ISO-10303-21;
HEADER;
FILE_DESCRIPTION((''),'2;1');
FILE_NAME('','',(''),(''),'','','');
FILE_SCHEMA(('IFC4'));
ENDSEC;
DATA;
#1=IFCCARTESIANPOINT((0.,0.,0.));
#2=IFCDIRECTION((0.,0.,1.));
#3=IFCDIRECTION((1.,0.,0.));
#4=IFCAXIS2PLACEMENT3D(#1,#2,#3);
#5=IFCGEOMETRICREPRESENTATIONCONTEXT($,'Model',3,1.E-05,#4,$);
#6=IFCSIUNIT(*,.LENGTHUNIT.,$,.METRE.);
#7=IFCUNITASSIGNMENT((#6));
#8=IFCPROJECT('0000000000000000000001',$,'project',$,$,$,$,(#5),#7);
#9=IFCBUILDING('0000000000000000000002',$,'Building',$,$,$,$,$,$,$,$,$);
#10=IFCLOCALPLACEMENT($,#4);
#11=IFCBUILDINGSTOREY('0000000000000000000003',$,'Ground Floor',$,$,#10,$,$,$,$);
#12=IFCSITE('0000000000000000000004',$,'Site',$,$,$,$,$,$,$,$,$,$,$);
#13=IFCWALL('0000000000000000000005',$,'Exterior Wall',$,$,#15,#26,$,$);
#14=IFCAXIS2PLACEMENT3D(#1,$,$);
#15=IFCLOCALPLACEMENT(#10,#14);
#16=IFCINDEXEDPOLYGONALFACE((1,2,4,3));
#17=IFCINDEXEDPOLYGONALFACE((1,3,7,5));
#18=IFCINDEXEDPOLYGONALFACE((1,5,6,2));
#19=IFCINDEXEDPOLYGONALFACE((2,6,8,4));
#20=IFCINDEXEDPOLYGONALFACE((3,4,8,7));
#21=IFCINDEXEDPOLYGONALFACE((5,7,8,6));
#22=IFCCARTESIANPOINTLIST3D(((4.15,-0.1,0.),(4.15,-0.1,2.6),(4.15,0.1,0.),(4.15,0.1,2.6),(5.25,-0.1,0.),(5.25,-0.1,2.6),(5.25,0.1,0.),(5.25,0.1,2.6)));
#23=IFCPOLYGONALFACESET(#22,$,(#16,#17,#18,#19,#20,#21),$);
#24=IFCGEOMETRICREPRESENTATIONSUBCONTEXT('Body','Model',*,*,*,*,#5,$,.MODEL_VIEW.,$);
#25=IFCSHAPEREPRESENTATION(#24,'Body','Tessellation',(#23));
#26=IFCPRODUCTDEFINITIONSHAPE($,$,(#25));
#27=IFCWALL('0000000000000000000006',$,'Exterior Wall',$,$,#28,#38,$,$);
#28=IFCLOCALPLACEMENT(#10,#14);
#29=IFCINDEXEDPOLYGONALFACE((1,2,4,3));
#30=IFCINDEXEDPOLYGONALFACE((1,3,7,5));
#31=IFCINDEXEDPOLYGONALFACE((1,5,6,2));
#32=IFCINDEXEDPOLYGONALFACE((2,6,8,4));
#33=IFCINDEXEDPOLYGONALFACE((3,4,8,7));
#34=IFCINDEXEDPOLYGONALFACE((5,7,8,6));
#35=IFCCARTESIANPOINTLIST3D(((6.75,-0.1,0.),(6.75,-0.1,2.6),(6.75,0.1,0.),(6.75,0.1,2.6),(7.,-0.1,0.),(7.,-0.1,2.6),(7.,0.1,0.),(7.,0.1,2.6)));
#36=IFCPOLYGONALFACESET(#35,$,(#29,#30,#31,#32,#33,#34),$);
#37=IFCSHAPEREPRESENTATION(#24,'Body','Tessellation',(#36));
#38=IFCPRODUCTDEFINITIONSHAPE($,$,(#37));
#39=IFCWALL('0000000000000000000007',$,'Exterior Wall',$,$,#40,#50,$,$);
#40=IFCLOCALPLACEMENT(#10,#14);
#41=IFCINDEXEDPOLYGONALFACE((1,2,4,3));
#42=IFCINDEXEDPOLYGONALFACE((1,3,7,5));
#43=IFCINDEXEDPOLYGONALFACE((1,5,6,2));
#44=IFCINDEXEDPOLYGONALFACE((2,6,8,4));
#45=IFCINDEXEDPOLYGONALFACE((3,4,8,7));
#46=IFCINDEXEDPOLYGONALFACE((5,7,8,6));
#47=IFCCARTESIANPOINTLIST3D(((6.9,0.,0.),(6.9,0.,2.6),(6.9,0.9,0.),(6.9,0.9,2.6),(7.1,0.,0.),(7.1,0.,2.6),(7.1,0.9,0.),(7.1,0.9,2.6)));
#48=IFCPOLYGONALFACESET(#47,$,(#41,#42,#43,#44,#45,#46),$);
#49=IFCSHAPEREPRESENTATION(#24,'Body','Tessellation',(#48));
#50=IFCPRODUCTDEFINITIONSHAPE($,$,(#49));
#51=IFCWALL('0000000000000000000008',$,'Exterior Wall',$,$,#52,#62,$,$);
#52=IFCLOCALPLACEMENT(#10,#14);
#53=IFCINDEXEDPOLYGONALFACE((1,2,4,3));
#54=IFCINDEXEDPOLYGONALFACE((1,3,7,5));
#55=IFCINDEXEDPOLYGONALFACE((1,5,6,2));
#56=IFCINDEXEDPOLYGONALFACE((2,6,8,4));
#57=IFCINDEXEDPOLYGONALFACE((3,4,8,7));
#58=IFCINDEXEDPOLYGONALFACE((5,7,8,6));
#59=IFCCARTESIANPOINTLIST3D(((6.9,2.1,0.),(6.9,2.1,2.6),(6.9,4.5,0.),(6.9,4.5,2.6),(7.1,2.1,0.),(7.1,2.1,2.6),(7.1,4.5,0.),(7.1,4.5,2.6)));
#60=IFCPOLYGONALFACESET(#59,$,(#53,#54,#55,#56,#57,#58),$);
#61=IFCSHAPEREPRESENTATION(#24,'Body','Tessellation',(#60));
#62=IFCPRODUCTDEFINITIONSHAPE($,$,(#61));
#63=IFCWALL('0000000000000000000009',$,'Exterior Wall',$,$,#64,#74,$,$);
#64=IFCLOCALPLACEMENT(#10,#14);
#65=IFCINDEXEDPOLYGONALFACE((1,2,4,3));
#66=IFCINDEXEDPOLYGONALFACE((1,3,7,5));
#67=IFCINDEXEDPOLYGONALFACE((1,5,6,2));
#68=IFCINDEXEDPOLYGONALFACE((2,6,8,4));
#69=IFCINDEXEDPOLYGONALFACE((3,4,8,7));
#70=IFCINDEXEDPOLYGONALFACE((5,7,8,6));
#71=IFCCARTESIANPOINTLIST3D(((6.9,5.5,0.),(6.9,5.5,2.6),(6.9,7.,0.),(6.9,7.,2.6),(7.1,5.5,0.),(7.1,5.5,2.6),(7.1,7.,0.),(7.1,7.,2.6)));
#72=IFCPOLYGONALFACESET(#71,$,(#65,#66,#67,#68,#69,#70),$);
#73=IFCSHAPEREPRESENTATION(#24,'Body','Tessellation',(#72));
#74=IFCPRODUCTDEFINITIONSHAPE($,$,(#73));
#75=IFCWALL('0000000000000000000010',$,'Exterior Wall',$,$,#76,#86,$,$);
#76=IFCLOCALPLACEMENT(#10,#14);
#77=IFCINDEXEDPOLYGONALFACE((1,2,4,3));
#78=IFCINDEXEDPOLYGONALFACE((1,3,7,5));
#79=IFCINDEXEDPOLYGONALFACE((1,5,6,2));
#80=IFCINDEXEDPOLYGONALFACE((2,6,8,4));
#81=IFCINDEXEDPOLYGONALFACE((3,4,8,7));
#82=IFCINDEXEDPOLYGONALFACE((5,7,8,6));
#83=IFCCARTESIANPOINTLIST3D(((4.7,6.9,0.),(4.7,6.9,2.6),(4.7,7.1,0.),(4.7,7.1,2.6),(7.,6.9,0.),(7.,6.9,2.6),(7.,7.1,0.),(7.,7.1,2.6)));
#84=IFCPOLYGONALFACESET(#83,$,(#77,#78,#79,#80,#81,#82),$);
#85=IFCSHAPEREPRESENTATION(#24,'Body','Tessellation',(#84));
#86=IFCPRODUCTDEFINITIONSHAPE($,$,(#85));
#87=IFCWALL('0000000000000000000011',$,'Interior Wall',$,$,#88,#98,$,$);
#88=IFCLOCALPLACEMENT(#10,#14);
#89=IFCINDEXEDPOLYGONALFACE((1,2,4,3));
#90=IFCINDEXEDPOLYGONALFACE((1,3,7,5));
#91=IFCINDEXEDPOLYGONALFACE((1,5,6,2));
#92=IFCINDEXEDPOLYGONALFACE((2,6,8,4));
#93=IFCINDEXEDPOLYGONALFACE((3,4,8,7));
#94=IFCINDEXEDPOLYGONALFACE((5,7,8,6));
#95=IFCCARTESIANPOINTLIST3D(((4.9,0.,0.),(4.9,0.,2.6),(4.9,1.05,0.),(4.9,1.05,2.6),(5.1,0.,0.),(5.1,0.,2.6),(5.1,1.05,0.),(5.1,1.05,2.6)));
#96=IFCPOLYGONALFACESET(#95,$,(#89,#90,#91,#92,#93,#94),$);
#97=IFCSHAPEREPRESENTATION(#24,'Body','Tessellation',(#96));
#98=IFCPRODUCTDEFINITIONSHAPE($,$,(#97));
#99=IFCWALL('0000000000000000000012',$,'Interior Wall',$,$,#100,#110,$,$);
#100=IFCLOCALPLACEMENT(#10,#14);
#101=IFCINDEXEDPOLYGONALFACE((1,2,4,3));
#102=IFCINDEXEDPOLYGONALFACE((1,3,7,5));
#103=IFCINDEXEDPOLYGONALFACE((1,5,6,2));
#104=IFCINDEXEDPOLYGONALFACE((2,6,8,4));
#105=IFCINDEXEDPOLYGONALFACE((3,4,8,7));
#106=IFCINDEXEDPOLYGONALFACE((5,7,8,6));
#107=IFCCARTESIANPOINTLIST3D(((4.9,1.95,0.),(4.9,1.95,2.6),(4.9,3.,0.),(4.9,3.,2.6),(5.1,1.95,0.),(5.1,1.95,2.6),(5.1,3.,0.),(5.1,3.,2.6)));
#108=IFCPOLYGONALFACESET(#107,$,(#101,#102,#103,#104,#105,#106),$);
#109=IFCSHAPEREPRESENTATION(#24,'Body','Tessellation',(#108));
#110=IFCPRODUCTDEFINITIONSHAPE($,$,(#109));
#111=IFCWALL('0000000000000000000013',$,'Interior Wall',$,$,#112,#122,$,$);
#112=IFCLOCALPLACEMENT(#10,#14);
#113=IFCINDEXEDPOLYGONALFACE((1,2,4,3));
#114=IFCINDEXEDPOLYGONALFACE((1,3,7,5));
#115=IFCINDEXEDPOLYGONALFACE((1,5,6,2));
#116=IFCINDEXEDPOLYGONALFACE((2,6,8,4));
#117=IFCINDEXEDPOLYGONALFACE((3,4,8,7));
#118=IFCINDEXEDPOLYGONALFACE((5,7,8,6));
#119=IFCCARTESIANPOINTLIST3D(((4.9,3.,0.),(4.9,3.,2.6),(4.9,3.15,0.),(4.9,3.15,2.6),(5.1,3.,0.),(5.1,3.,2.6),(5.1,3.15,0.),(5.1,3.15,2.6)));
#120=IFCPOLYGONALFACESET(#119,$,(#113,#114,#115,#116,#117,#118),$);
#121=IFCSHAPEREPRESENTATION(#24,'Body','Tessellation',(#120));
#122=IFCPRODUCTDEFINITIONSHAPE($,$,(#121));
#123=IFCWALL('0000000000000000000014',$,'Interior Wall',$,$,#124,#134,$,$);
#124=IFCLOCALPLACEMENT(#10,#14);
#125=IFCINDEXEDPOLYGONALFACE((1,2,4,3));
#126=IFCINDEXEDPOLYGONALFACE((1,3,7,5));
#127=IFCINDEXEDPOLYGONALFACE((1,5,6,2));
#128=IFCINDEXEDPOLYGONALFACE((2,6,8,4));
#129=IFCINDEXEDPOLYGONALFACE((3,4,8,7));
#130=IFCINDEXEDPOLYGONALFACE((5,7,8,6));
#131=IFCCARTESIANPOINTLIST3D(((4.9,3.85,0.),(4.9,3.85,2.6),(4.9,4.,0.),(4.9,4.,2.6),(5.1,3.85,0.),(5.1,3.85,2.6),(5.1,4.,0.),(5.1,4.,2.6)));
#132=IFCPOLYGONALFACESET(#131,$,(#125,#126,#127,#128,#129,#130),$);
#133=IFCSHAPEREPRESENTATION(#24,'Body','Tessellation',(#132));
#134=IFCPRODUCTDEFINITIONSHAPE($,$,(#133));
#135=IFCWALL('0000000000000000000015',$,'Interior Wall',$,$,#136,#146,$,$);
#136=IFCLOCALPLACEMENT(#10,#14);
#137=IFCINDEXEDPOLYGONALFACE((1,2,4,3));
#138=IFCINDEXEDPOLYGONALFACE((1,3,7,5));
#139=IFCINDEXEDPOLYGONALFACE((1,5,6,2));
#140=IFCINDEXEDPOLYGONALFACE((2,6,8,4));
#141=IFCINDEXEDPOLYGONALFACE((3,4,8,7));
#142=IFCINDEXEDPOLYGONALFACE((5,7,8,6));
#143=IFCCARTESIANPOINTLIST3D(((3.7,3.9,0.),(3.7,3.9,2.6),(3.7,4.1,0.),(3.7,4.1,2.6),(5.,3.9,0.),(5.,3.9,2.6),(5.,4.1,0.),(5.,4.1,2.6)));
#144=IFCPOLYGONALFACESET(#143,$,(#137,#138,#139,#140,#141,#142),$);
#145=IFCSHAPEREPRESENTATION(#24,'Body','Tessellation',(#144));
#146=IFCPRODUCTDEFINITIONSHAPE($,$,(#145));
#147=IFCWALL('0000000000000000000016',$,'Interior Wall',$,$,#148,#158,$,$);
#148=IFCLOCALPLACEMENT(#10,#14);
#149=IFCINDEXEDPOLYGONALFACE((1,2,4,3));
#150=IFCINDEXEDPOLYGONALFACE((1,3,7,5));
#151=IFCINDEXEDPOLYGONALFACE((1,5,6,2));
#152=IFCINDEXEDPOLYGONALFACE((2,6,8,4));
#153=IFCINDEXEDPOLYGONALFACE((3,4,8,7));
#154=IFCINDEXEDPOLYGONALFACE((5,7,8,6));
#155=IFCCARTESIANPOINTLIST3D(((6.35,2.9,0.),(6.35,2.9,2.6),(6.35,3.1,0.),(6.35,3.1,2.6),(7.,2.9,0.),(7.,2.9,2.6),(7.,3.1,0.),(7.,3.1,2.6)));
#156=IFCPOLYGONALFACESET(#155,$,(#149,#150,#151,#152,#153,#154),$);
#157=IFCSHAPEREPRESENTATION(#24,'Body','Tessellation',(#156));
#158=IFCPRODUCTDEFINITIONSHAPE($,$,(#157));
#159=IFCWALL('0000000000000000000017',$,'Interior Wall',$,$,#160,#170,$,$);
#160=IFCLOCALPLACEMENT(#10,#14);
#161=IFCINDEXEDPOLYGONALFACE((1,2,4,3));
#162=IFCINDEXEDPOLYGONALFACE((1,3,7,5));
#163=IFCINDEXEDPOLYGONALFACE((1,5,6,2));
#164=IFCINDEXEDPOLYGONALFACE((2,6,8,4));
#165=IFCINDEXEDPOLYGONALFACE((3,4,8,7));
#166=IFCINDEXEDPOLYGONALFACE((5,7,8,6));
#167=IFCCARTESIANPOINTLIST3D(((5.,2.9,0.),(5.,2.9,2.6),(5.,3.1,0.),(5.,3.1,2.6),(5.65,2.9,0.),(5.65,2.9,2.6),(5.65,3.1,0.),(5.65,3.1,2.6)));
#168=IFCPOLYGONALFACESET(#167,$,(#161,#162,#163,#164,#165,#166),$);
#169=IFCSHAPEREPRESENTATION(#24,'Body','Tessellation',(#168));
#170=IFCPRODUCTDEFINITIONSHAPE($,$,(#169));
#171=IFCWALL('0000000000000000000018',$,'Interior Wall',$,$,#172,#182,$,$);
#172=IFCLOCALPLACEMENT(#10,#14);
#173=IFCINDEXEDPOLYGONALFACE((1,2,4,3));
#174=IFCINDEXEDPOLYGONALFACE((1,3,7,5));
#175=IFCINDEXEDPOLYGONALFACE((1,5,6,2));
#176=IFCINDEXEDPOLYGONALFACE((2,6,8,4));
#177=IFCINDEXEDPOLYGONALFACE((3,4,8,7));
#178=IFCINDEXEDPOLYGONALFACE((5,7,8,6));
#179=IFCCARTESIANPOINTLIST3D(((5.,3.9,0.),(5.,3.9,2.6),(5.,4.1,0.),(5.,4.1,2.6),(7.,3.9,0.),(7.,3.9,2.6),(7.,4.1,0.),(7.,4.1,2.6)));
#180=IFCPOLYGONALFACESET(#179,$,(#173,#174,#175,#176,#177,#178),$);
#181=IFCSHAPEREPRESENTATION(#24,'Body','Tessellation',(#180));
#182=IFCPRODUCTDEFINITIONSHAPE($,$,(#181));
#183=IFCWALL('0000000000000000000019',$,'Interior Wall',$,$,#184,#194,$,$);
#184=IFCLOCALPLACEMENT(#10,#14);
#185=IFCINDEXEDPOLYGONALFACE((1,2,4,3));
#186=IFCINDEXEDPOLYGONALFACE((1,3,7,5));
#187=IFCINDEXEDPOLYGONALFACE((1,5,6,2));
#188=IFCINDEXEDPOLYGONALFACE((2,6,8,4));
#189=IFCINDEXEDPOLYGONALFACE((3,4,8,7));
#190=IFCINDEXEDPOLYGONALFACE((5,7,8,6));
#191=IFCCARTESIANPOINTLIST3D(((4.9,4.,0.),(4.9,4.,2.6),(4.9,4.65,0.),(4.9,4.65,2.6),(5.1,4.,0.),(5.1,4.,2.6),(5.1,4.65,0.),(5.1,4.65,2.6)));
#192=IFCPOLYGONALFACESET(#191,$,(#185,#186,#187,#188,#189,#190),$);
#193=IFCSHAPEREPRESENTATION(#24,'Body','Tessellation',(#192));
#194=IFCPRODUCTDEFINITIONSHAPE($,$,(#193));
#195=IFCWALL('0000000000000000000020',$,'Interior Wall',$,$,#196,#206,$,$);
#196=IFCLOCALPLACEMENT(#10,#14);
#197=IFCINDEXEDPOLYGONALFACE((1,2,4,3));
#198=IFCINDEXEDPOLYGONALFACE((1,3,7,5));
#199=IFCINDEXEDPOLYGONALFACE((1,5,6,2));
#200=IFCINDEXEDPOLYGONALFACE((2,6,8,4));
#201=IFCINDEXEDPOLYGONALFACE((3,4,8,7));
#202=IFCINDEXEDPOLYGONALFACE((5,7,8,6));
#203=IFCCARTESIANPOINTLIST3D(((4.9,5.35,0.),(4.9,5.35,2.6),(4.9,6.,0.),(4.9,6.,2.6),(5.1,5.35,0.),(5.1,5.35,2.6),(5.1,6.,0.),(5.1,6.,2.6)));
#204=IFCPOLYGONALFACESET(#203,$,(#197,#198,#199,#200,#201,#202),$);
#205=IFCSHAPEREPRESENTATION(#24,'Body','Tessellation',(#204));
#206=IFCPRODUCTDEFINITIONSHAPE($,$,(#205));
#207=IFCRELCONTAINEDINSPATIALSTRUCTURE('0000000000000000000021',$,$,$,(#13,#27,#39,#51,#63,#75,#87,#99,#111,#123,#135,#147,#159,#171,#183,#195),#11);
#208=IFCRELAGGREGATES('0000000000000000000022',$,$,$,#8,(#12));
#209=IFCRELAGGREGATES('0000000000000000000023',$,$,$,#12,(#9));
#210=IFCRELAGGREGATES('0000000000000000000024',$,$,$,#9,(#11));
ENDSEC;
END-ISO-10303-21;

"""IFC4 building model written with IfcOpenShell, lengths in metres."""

from ifc_helpers import new_model, si_unit, frame, origin_with_axes, place, context, subcontext, project, spatial, indexed_curve, outline, extrude, element, save


model = new_model("IFC4")

# Units and contexts
model_context = context("Model", 3, precision=1e-05, world=origin_with_axes())
body_context = subcontext(model_context, "Body", "Model", "MODEL_VIEW")
ifc_project = project(units=[si_unit("LENGTHUNIT", "METRE")], contexts=[model_context])

# Site, building, storey
site = spatial("IfcSite", under=ifc_project, Name="Site")
building = spatial("IfcBuilding", under=site, Name="Building")
storey_placement = place(None, origin_with_axes())
storey = spatial("IfcBuildingStorey", under=building, at=storey_placement, Name="Ground Floor")

# Walls
wall_1_placement = place(storey_placement, frame((4.15, 0.0, 0.0), z_axis=(0.0, 0.0, 1.0), x_axis=(1.0, 0.0, 0.0)))
element("IfcWall", 1, at=wall_1_placement, inside=storey, Name="Exterior Wall", context=body_context, shape_type="SweptSolid", body=[
    extrude(outline(indexed_curve([(0.0, 0.0), (0.0, 0.2), (1.1, 0.2), (1.1, 0.0), (0.0, 0.0)], self_intersect=False)), frame((0.0, -0.1, 0.0), z_axis=(0.0, 0.0, 1.0), x_axis=(1.0, 0.0, 0.0)), (0.0, 0.0, 1.0), 2.6),
])
wall_2_placement = place(storey_placement, frame((6.75, 0.0, 0.0), z_axis=(0.0, 0.0, 1.0), x_axis=(1.0, 0.0, 0.0)))
element("IfcWall", 2, at=wall_2_placement, inside=storey, Name="Exterior Wall", context=body_context, shape_type="SweptSolid", body=[
    extrude(outline(indexed_curve([(0.0, 0.0), (0.0, 0.2), (0.25, 0.2), (0.25, 0.0), (0.0, 0.0)], self_intersect=False)), frame((0.0, -0.1, 0.0), z_axis=(0.0, 0.0, 1.0), x_axis=(1.0, 0.0, 0.0)), (0.0, 0.0, 1.0), 2.6),
])
wall_3_placement = place(storey_placement, frame((7.0, 0.0, 0.0), z_axis=(0.0, 0.0, 1.0), x_axis=(0.0, 1.0, 0.0)))
element("IfcWall", 3, at=wall_3_placement, inside=storey, Name="Exterior Wall", context=body_context, shape_type="SweptSolid", body=[
    extrude(outline(indexed_curve([(0.0, 0.0), (0.0, 0.2), (0.9, 0.2), (0.9, 0.0), (0.0, 0.0)], self_intersect=False)), frame((0.0, -0.1, 0.0), z_axis=(0.0, 0.0, 1.0), x_axis=(1.0, 0.0, 0.0)), (0.0, 0.0, 1.0), 2.6),
])
wall_4_placement = place(storey_placement, frame((7.0, 2.1, 0.0), z_axis=(0.0, 0.0, 1.0), x_axis=(0.0, 1.0, 0.0)))
element("IfcWall", 4, at=wall_4_placement, inside=storey, Name="Exterior Wall", context=body_context, shape_type="SweptSolid", body=[
    extrude(outline(indexed_curve([(0.0, 0.0), (0.0, 0.2), (2.4, 0.2), (2.4, 0.0), (0.0, 0.0)], self_intersect=False)), frame((0.0, -0.1, 0.0), z_axis=(0.0, 0.0, 1.0), x_axis=(1.0, 0.0, 0.0)), (0.0, 0.0, 1.0), 2.6),
])
wall_5_placement = place(storey_placement, frame((7.0, 5.5, 0.0), z_axis=(0.0, 0.0, 1.0), x_axis=(0.0, 1.0, 0.0)))
element("IfcWall", 5, at=wall_5_placement, inside=storey, Name="Exterior Wall", context=body_context, shape_type="SweptSolid", body=[
    extrude(outline(indexed_curve([(0.0, 0.0), (0.0, 0.2), (1.5, 0.2), (1.5, 0.0), (0.0, 0.0)], self_intersect=False)), frame((0.0, -0.1, 0.0), z_axis=(0.0, 0.0, 1.0), x_axis=(1.0, 0.0, 0.0)), (0.0, 0.0, 1.0), 2.6),
])
wall_6_placement = place(storey_placement, frame((7.0, 7.0, 0.0), z_axis=(0.0, 0.0, 1.0), x_axis=(-1.0, 0.0, 0.0)))
element("IfcWall", 6, at=wall_6_placement, inside=storey, Name="Exterior Wall", context=body_context, shape_type="SweptSolid", body=[
    extrude(outline(indexed_curve([(0.0, 0.0), (0.0, 0.2), (2.3, 0.2), (2.3, 0.0), (0.0, 0.0)], self_intersect=False)), frame((0.0, -0.1, 0.0), z_axis=(0.0, 0.0, 1.0), x_axis=(1.0, 0.0, 0.0)), (0.0, 0.0, 1.0), 2.6),
])
for number, where, z_axis, x_axis, name in (
    (7, (5.0, 0.0, 0.0), (0.0, 0.0, 1.0), (0.0, 1.0, 0.0), "Interior Wall"),
    (8, (5.0, 1.95, 0.0), (0.0, 0.0, 1.0), (0.0, 1.0, 0.0), "Interior Wall"),
):
    element("IfcWall", number, at=place(storey_placement, frame(where, z_axis=z_axis, x_axis=x_axis)), inside=storey, Name=name, context=body_context, shape_type="SweptSolid", body=[
        extrude(outline(indexed_curve([(0.0, 0.0), (0.0, 0.2), (1.05, 0.2), (1.05, 0.0), (0.0, 0.0)], self_intersect=False)), frame((0.0, -0.1, 0.0), z_axis=(0.0, 0.0, 1.0), x_axis=(1.0, 0.0, 0.0)), (0.0, 0.0, 1.0), 2.6),
    ])
for number, where, z_axis, x_axis, name in (
    (9, (5.0, 3.0, 0.0), (0.0, 0.0, 1.0), (0.0, 1.0, 0.0), "Interior Wall"),
    (10, (5.0, 3.85, 0.0), (0.0, 0.0, 1.0), (0.0, 1.0, 0.0), "Interior Wall"),
):
    element("IfcWall", number, at=place(storey_placement, frame(where, z_axis=z_axis, x_axis=x_axis)), inside=storey, Name=name, context=body_context, shape_type="SweptSolid", body=[
        extrude(outline(indexed_curve([(0.0, 0.0), (0.0, 0.2), (0.15, 0.2), (0.15, 0.0), (0.0, 0.0)], self_intersect=False)), frame((0.0, -0.1, 0.0), z_axis=(0.0, 0.0, 1.0), x_axis=(1.0, 0.0, 0.0)), (0.0, 0.0, 1.0), 2.6),
    ])
wall_7_placement = place(storey_placement, frame((5.0, 4.0, 0.0), z_axis=(0.0, 0.0, 1.0), x_axis=(-1.0, 0.0, 0.0)))
element("IfcWall", 11, at=wall_7_placement, inside=storey, Name="Interior Wall", context=body_context, shape_type="SweptSolid", body=[
    extrude(outline(indexed_curve([(0.0, 0.0), (0.0, 0.2), (1.3, 0.2), (1.3, 0.0), (0.0, 0.0)], self_intersect=False)), frame((0.0, -0.1, 0.0), z_axis=(0.0, 0.0, 1.0), x_axis=(1.0, 0.0, 0.0)), (0.0, 0.0, 1.0), 2.6),
])
for number, where, z_axis, x_axis, name in (
    (12, (7.0, 3.0, 0.0), (0.0, 0.0, 1.0), (-1.0, 0.0, 0.0), "Interior Wall"),
    (13, (5.65, 3.0, 0.0), (0.0, 0.0, 1.0), (-1.0, 0.0, 0.0), "Interior Wall"),
):
    element("IfcWall", number, at=place(storey_placement, frame(where, z_axis=z_axis, x_axis=x_axis)), inside=storey, Name=name, context=body_context, shape_type="SweptSolid", body=[
        extrude(outline(indexed_curve([(0.0, 0.0), (0.0, 0.2), (0.65, 0.2), (0.65, 0.0), (0.0, 0.0)], self_intersect=False)), frame((0.0, -0.1, 0.0), z_axis=(0.0, 0.0, 1.0), x_axis=(1.0, 0.0, 0.0)), (0.0, 0.0, 1.0), 2.6),
    ])
wall_8_placement = place(storey_placement, frame((7.0, 4.0, 0.0), z_axis=(0.0, 0.0, 1.0), x_axis=(-1.0, 0.0, 0.0)))
element("IfcWall", 14, at=wall_8_placement, inside=storey, Name="Interior Wall", context=body_context, shape_type="SweptSolid", body=[
    extrude(outline(indexed_curve([(0.0, 0.0), (0.0, 0.2), (2.0, 0.2), (2.0, 0.0), (0.0, 0.0)], self_intersect=False)), frame((0.0, -0.1, 0.0), z_axis=(0.0, 0.0, 1.0), x_axis=(1.0, 0.0, 0.0)), (0.0, 0.0, 1.0), 2.6),
])
for number, where, z_axis, x_axis, name in (
    (15, (5.0, 4.0, 0.0), (0.0, 0.0, 1.0), (0.0, 1.0, 0.0), "Interior Wall"),
    (16, (5.0, 5.35, 0.0), (0.0, 0.0, 1.0), (0.0, 1.0, 0.0), "Interior Wall"),
):
    element("IfcWall", number, at=place(storey_placement, frame(where, z_axis=z_axis, x_axis=x_axis)), inside=storey, Name=name, context=body_context, shape_type="SweptSolid", body=[
        extrude(outline(indexed_curve([(0.0, 0.0), (0.0, 0.2), (0.65, 0.2), (0.65, 0.0), (0.0, 0.0)], self_intersect=False)), frame((0.0, -0.1, 0.0), z_axis=(0.0, 0.0, 1.0), x_axis=(1.0, 0.0, 0.0)), (0.0, 0.0, 1.0), 2.6),
    ])

save(model, "model.ifc")
